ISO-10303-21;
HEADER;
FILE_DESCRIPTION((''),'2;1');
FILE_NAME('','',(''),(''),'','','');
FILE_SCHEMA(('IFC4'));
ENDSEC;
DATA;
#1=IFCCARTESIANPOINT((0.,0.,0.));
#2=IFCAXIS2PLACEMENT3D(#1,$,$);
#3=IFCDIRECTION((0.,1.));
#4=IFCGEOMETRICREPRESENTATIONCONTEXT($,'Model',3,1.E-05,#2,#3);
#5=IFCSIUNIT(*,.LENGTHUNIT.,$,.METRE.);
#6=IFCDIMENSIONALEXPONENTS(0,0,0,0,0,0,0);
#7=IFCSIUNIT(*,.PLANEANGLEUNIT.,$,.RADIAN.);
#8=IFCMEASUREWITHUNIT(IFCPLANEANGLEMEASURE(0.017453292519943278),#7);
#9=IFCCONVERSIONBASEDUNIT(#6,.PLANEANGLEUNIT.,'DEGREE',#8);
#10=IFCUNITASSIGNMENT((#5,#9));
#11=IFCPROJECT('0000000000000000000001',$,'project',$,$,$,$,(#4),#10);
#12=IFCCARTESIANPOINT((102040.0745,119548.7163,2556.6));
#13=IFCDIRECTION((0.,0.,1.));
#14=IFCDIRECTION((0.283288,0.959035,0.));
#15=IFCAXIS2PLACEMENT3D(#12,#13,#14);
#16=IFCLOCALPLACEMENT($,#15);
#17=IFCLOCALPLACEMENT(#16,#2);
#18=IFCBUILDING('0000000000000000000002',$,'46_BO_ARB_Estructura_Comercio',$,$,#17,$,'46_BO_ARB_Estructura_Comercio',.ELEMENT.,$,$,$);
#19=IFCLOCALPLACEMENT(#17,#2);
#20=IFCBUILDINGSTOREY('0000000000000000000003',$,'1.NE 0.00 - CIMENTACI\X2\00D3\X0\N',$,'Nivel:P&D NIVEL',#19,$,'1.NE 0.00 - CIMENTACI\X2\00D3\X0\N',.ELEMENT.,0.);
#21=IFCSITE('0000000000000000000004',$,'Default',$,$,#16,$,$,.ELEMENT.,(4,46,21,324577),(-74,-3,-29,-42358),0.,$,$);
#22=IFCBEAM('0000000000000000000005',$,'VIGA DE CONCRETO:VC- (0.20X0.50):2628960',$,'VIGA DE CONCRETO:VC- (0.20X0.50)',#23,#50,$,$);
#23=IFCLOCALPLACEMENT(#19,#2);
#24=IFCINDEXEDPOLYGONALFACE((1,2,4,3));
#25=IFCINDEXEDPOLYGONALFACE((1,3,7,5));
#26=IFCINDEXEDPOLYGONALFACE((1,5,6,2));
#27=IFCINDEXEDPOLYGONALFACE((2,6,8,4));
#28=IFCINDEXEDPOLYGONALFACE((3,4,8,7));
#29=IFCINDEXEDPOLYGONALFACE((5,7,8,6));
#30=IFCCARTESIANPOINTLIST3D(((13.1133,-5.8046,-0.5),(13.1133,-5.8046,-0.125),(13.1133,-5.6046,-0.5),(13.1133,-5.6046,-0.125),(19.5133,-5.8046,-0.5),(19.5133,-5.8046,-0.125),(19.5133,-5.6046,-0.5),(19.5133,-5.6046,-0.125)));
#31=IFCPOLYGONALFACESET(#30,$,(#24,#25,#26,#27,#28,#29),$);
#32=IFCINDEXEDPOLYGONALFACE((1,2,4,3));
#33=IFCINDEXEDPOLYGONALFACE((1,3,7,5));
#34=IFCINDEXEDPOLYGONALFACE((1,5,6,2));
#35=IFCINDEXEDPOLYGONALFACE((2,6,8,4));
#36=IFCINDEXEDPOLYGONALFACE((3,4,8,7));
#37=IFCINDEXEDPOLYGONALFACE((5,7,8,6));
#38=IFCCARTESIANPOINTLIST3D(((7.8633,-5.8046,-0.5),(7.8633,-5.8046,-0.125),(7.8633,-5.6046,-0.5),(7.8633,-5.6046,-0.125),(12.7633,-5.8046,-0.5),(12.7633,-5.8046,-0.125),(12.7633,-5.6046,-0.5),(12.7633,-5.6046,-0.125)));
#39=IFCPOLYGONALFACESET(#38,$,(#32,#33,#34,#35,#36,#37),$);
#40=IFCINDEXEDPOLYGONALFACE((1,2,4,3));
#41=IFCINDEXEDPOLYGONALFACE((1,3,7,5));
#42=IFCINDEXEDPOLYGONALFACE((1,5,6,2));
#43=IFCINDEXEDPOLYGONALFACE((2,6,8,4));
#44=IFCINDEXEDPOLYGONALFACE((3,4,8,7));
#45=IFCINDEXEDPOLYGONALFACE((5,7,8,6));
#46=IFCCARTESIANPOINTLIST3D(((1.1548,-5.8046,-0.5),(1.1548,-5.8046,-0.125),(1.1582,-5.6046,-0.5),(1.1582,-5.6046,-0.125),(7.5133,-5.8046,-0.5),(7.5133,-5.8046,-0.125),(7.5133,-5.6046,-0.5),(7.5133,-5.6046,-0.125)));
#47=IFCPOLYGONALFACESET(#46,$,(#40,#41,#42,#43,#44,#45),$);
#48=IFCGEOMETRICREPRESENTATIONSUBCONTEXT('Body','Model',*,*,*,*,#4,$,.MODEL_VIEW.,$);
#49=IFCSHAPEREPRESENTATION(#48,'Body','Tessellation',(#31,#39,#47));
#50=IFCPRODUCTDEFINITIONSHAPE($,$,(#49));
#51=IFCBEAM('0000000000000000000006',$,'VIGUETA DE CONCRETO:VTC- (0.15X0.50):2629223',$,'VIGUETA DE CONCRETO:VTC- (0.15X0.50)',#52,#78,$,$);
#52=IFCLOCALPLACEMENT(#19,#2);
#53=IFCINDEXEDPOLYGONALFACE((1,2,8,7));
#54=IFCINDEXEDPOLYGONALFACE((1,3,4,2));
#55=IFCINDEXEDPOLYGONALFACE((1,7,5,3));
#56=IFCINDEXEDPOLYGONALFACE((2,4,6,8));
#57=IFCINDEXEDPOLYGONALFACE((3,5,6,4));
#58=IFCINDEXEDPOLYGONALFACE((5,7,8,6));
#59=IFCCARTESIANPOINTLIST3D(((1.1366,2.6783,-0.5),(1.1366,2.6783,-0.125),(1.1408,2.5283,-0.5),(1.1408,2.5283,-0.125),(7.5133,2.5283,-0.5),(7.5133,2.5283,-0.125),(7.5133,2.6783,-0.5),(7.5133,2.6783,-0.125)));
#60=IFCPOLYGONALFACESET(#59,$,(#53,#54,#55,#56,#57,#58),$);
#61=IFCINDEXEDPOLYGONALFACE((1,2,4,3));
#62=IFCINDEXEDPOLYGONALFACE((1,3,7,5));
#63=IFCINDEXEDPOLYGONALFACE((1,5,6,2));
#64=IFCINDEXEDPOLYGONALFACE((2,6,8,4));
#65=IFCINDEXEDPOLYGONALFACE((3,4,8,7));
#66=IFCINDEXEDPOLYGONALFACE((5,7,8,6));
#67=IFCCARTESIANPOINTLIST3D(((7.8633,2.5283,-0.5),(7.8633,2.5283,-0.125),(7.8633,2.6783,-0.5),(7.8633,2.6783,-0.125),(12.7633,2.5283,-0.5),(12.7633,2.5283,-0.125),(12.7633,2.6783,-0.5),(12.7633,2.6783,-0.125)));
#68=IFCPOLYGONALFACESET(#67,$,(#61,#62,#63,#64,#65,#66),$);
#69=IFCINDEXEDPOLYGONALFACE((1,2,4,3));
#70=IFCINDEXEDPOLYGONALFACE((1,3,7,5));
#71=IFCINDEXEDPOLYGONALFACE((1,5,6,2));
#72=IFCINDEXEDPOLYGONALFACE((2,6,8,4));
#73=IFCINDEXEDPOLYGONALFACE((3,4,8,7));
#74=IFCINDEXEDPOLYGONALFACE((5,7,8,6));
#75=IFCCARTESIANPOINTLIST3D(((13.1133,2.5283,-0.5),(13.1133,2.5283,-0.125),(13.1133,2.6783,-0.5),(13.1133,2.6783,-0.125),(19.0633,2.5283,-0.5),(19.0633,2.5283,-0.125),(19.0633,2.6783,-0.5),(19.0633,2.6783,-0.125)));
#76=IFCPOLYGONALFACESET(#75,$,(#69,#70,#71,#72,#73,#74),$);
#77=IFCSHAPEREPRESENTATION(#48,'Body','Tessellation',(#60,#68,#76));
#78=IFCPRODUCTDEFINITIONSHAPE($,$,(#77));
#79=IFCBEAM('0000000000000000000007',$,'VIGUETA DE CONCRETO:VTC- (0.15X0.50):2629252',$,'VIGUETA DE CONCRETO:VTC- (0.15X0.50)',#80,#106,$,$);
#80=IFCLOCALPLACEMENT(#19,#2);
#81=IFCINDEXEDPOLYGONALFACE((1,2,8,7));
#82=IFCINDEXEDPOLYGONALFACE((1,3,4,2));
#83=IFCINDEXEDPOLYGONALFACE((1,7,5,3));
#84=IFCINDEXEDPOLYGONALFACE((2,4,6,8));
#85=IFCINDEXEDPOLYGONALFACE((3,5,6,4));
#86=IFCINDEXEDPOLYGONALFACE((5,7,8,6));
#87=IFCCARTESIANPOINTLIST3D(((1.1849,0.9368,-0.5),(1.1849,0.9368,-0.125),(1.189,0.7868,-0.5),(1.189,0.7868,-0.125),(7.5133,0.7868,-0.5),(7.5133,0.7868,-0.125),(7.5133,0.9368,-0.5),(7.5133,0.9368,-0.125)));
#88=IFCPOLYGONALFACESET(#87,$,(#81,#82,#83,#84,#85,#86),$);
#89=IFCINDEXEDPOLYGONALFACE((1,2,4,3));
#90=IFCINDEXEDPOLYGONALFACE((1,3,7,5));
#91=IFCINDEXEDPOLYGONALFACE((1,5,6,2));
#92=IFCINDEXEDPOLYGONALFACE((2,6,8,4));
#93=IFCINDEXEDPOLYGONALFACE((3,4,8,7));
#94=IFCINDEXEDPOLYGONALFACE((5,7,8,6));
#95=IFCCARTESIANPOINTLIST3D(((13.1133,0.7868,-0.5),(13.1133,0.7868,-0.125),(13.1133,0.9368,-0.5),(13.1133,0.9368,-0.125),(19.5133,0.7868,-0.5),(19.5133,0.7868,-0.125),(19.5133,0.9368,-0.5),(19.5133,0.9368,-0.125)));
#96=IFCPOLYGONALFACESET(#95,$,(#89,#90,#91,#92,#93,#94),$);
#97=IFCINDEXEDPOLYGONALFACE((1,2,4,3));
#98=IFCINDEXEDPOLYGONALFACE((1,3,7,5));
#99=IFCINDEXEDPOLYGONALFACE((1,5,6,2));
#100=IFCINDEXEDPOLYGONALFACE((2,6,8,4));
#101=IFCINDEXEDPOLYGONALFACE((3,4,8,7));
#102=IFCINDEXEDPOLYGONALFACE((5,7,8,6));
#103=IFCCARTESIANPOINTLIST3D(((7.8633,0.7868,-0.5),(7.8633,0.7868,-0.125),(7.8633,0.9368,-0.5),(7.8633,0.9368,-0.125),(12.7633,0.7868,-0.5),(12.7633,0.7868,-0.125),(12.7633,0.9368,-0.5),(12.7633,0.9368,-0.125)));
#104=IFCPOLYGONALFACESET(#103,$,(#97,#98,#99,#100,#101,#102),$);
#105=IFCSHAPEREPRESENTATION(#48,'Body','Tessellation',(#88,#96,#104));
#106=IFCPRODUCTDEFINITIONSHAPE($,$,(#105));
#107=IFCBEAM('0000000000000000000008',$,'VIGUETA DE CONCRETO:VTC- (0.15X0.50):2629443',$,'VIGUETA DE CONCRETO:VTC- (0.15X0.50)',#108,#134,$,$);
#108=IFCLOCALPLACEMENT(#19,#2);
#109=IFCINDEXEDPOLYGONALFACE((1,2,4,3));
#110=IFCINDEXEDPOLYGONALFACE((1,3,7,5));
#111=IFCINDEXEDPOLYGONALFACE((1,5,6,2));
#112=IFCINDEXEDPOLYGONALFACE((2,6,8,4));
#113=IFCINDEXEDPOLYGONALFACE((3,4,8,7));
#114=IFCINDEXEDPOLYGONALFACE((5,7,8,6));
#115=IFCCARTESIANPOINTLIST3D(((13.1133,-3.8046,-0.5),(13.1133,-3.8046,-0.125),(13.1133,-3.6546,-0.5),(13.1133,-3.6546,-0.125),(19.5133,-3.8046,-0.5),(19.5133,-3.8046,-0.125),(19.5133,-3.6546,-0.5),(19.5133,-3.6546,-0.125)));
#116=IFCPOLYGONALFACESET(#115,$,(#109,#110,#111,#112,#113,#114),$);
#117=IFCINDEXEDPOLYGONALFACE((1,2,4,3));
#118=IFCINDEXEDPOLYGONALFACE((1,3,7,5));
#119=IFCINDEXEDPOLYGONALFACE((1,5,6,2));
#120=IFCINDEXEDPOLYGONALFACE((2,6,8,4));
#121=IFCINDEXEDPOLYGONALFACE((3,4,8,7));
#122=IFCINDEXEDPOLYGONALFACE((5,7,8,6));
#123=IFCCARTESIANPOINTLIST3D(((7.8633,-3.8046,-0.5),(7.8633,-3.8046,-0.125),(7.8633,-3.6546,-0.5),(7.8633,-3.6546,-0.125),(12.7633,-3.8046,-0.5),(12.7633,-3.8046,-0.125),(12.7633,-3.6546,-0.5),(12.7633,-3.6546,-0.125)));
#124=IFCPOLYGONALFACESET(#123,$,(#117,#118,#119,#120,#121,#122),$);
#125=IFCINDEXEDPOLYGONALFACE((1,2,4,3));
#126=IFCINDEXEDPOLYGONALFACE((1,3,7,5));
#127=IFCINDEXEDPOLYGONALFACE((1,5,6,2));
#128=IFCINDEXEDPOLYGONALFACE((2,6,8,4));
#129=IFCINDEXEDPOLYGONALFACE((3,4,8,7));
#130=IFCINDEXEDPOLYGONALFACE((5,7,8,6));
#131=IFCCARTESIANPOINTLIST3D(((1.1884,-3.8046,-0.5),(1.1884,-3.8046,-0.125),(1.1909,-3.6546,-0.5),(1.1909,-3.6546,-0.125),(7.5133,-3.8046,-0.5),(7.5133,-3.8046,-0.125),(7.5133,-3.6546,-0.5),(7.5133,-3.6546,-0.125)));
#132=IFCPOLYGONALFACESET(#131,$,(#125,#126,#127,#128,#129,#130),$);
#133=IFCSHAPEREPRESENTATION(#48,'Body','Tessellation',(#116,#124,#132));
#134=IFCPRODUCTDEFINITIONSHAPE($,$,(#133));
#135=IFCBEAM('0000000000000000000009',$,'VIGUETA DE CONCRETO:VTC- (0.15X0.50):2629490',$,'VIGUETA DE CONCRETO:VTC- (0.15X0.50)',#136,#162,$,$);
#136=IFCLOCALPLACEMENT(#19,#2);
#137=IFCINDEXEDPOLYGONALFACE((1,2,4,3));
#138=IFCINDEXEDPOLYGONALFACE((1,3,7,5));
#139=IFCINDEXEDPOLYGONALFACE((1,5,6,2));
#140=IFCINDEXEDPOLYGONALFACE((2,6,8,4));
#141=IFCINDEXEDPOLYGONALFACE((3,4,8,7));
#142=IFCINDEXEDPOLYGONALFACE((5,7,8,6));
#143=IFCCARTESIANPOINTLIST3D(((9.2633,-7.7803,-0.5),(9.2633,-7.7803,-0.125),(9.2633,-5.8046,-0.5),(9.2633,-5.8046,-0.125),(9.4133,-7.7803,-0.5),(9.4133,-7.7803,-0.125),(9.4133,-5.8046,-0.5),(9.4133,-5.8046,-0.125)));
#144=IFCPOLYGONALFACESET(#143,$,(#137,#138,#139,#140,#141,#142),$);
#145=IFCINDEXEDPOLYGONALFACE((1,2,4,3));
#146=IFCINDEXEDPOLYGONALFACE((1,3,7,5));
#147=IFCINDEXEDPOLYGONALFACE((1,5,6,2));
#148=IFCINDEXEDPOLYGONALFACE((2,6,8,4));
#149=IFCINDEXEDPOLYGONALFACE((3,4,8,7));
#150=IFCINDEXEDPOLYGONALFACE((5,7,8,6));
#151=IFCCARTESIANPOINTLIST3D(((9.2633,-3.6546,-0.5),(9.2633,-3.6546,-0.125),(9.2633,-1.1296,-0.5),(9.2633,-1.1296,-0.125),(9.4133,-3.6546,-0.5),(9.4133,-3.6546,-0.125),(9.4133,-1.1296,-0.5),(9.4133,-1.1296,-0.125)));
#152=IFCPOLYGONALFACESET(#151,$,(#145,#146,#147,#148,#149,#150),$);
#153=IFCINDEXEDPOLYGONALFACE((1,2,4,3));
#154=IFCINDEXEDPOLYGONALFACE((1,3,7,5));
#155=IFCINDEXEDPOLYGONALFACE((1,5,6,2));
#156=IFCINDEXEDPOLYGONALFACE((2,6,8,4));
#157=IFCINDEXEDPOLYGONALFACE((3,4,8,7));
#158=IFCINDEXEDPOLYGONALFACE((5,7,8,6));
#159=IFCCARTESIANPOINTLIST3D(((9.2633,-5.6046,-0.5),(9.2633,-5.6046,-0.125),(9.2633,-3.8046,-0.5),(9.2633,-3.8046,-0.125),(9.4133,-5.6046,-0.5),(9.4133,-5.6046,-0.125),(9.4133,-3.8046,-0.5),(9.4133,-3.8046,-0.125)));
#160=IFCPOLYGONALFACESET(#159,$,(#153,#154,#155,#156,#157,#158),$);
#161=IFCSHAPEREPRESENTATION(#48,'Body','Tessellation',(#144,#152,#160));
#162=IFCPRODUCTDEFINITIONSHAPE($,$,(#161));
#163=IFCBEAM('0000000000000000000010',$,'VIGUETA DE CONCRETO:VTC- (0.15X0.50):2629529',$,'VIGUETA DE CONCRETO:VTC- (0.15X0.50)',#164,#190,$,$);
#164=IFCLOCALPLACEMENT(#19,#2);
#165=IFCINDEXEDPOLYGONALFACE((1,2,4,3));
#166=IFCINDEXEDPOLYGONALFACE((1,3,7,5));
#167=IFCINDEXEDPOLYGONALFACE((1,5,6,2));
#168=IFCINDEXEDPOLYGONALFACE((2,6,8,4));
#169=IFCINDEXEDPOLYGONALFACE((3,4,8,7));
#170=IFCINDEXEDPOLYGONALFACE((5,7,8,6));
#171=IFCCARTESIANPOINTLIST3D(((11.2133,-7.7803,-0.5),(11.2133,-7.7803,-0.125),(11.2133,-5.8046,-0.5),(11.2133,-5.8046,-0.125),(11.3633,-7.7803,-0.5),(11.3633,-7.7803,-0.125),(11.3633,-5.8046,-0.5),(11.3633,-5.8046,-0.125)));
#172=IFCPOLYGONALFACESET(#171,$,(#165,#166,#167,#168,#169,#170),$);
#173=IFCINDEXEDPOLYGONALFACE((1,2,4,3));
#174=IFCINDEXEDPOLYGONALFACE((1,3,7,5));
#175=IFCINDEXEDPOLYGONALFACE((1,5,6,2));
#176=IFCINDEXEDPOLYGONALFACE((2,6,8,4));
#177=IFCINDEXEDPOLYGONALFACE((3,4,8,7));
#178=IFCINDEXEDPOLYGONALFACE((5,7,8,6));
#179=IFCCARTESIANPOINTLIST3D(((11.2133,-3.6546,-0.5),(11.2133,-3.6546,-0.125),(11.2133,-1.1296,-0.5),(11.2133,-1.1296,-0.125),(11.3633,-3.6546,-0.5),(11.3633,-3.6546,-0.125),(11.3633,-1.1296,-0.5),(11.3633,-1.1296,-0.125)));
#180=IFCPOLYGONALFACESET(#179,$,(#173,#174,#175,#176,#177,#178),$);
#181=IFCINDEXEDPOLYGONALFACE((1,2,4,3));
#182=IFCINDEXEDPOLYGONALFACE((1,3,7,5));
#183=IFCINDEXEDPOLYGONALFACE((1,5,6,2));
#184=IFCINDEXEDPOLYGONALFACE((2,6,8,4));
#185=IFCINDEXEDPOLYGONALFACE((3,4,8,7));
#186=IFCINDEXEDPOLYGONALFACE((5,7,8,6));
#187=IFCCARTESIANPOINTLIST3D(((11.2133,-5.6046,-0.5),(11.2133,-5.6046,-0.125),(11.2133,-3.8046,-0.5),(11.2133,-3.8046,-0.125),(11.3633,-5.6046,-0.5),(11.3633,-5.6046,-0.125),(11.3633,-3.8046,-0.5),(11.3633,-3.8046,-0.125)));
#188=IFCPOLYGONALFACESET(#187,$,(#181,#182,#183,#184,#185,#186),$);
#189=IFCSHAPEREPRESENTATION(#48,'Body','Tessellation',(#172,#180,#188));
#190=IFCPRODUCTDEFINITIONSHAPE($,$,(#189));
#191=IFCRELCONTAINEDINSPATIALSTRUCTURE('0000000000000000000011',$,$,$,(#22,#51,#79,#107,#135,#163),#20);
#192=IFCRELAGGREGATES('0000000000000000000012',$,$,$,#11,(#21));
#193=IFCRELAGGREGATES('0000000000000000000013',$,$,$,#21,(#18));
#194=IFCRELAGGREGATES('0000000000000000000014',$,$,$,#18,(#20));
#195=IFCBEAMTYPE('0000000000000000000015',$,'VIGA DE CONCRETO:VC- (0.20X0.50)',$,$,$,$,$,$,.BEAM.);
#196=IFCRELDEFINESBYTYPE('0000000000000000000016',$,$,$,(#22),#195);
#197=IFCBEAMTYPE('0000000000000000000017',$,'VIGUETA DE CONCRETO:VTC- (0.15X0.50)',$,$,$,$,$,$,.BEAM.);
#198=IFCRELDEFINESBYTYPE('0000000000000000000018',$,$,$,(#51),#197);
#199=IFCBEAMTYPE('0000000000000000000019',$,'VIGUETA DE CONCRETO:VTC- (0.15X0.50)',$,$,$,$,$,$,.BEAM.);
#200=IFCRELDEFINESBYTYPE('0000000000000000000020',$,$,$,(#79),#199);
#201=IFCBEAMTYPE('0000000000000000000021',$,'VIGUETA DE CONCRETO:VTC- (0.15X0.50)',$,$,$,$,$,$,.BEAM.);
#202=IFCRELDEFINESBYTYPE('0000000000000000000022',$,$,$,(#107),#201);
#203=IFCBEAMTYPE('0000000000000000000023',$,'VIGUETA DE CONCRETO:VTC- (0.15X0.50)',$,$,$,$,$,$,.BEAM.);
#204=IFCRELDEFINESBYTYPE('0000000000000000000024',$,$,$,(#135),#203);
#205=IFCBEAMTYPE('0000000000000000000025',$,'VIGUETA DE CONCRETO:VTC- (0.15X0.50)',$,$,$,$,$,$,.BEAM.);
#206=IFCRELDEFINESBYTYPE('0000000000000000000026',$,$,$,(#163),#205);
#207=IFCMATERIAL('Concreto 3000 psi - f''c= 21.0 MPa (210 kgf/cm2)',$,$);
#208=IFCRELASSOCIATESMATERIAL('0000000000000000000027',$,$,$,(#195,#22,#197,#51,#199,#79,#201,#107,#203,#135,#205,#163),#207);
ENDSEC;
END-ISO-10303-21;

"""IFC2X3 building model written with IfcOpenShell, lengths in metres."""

from ifc_helpers import new_model, entity, si_unit, converted_unit, direction, frame, frame_2d, origin, origin_2d_with_axis, place, context, subcontext, project, spatial, rectangle, extrude, clip, halfspace, source, transform, mapped, material, type_object, type_shapes, element, save


model = new_model("IFC2X3")

# Units and contexts
model_context = context("Model", 3, precision=1e-05, world=origin(), true_north=direction((0.0, 1.0)))
body_context = subcontext(model_context, "Body", "Model", "MODEL_VIEW")
ifc_project = project(units=[si_unit("LENGTHUNIT", "METRE"), converted_unit("PLANEANGLEUNIT", "DEGREE", entity("IfcPlaneAngleMeasure", 0.017453292519943278), si_unit("PLANEANGLEUNIT", "RADIAN"), dimensions=[0, 0, 0, 0, 0, 0, 0])], contexts=[model_context])

# Site, building, storey
site_placement = place(None, frame((102040.0745, 119548.7163, 2556.6), z_axis=(0.0, 0.0, 1.0), x_axis=(0.283288, 0.959035, 0.0)))
site = spatial("IfcSite", under=ifc_project, at=site_placement, Name="Default", CompositionType="ELEMENT", RefLatitude=(4, 46, 21, 324577), RefLongitude=(-74, -3, -29, -42358), RefElevation=0.0)
building_placement = place(site_placement, origin())
building = spatial("IfcBuilding", under=site, at=building_placement, Name="46_BO_ARB_Estructura_Comercio", LongName="46_BO_ARB_Estructura_Comercio", CompositionType="ELEMENT")
storey_placement = place(building_placement, origin())
storey = spatial("IfcBuildingStorey", under=building, at=storey_placement, Name="1.NE 0.00 - CIMENTACIÓN", ObjectType="Nivel:P&D NIVEL", LongName="1.NE 0.00 - CIMENTACIÓN", CompositionType="ELEMENT", Elevation=0.0)

# Beams
ifc_material_1 = material(Name="Concreto 3000 psi - f'c= 21.0 MPa (210 kgf/cm2)")
beam_type_1 = type_object("IfcBeamType", Name="VIGA DE CONCRETO:VC- (0.20X0.50)", PredefinedType="BEAM", material=ifc_material_1)
shared_shape_1 = source(origin(), body_context, "Body", "SweptSolid", [
    extrude(rectangle(XDim=0.375, YDim=0.2, at=frame_2d((0.0, 0.0), x_axis=(1.0, 0.0))), frame((13.1133, -5.7046, -0.3125), z_axis=(1.0, 0.0, 0.0), x_axis=(0.0, 0.0, -1.0)), (0.0, 0.0, 1.0), 6.4),
    extrude(rectangle(XDim=0.375, YDim=0.2, at=frame_2d((0.0, 0.0), x_axis=(1.0, 0.0))), frame((7.8633, -5.7046, -0.3125), z_axis=(1.0, 0.0, 0.0), x_axis=(0.0, 0.0, -1.0)), (0.0, 0.0, 1.0), 4.9),
    clip(extrude(rectangle(XDim=0.375, YDim=0.2, at=origin_2d_with_axis()), frame((1.1548, -5.7046, -0.3125), z_axis=(1.0, 0.0, 0.0), x_axis=(0.0, 0.0, -1.0)), (0.0, 0.0, 1.0), 6.3585), halfspace(frame((1.2358, -0.978, 0.0), z_axis=(-0.999859, 0.016768, 0.0), x_axis=(-0.016768, -0.999859, 0.0)), False)),
])
type_shapes(beam_type_1, [shared_shape_1])
beam_1_placement = place(storey_placement, origin())
element("IfcBeam", 1, at=beam_1_placement, inside=storey, type_object=beam_type_1, material=ifc_material_1, Name="VIGA DE CONCRETO:VC- (0.20X0.50):2628960", ObjectType="VIGA DE CONCRETO:VC- (0.20X0.50)", context=body_context, shape_type="MappedRepresentation", body=[
    mapped(shared_shape_1, transform((0.0, 0.0, 0.0), scale=1.0)),
])
beam_type_2 = type_object("IfcBeamType", Name="VIGUETA DE CONCRETO:VTC- (0.15X0.50)", PredefinedType="BEAM", material=ifc_material_1)
shared_shape_2 = source(origin(), body_context, "Body", "SweptSolid", [
    clip(extrude(rectangle(XDim=0.375, YDim=0.15, at=frame_2d((0.0, 0.0), x_axis=(1.0, 0.0))), frame((1.1366, 2.6033, -0.3125), z_axis=(1.0, 0.0, 0.0), x_axis=(0.0, 0.0, -1.0)), (0.0, 0.0, 1.0), 6.3767), halfspace(frame((1.0943, 4.207, 0.0), z_axis=(-0.999616, -0.027697, 0.0), x_axis=(0.027697, -0.999616, 0.0)), False)),
    extrude(rectangle(XDim=0.375, YDim=0.15, at=frame_2d((0.0, 0.0), x_axis=(1.0, 0.0))), frame((7.8633, 2.6033, -0.3125), z_axis=(1.0, 0.0, 0.0), x_axis=(0.0, 0.0, -1.0)), (0.0, 0.0, 1.0), 4.9),
    extrude(rectangle(XDim=0.375, YDim=0.15, at=frame_2d((0.0, 0.0), x_axis=(1.0, 0.0))), frame((13.1133, 2.6033, -0.3125), z_axis=(1.0, 0.0, 0.0), x_axis=(0.0, 0.0, -1.0)), (0.0, 0.0, 1.0), 5.95),
])
type_shapes(beam_type_2, [shared_shape_2])
beam_2_placement = place(storey_placement, origin())
element("IfcBeam", 2, at=beam_2_placement, inside=storey, type_object=beam_type_2, material=ifc_material_1, Name="VIGUETA DE CONCRETO:VTC- (0.15X0.50):2629223", ObjectType="VIGUETA DE CONCRETO:VTC- (0.15X0.50)", context=body_context, shape_type="MappedRepresentation", body=[
    mapped(shared_shape_2, transform((0.0, 0.0, 0.0), scale=1.0)),
])
beam_type_3 = type_object("IfcBeamType", Name="VIGUETA DE CONCRETO:VTC- (0.15X0.50)", PredefinedType="BEAM", material=ifc_material_1)
shared_shape_3 = source(origin(), body_context, "Body", "SweptSolid", [
    clip(extrude(rectangle(XDim=0.375, YDim=0.15, at=frame_2d((0.0, 0.0), x_axis=(1.0, 0.0))), frame((1.1849, 0.8618, -0.3125), z_axis=(1.0, 0.0, 0.0), x_axis=(0.0, 0.0, -1.0)), (0.0, 0.0, 1.0), 6.3284), halfspace(frame((1.0943, 4.207, 0.0), z_axis=(-0.999616, -0.027697, 0.0), x_axis=(0.027697, -0.999616, 0.0)), False)),
    extrude(rectangle(XDim=0.375, YDim=0.15, at=frame_2d((0.0, 0.0), x_axis=(1.0, 0.0))), frame((13.1133, 0.8618, -0.3125), z_axis=(1.0, 0.0, 0.0), x_axis=(0.0, 0.0, -1.0)), (0.0, 0.0, 1.0), 6.4),
    extrude(rectangle(XDim=0.375, YDim=0.15, at=frame_2d((0.0, 0.0), x_axis=(1.0, 0.0))), frame((7.8633, 0.8618, -0.3125), z_axis=(1.0, 0.0, 0.0), x_axis=(0.0, 0.0, -1.0)), (0.0, 0.0, 1.0), 4.9),
])
type_shapes(beam_type_3, [shared_shape_3])
beam_3_placement = place(storey_placement, origin())
element("IfcBeam", 3, at=beam_3_placement, inside=storey, type_object=beam_type_3, material=ifc_material_1, Name="VIGUETA DE CONCRETO:VTC- (0.15X0.50):2629252", ObjectType="VIGUETA DE CONCRETO:VTC- (0.15X0.50)", context=body_context, shape_type="MappedRepresentation", body=[
    mapped(shared_shape_3, transform((0.0, 0.0, 0.0), scale=1.0)),
])
beam_type_4 = type_object("IfcBeamType", Name="VIGUETA DE CONCRETO:VTC- (0.15X0.50)", PredefinedType="BEAM", material=ifc_material_1)
shared_shape_4 = source(origin(), body_context, "Body", "SweptSolid", [
    extrude(rectangle(XDim=0.375, YDim=0.15, at=origin_2d_with_axis()), frame((13.1133, -3.7296, -0.3125), z_axis=(1.0, 0.0, 0.0), x_axis=(0.0, 0.0, -1.0)), (0.0, 0.0, 1.0), 6.4),
    extrude(rectangle(XDim=0.375, YDim=0.15, at=origin_2d_with_axis()), frame((7.8633, -3.7296, -0.3125), z_axis=(1.0, 0.0, 0.0), x_axis=(0.0, 0.0, -1.0)), (0.0, 0.0, 1.0), 4.9),
    clip(extrude(rectangle(XDim=0.375, YDim=0.15, at=frame_2d((0.0, 0.0), x_axis=(1.0, 0.0))), frame((1.1884, -3.7296, -0.3125), z_axis=(1.0, 0.0, 0.0), x_axis=(0.0, 0.0, -1.0)), (0.0, 0.0, 1.0), 6.3249), halfspace(frame((1.2358, -0.978, 0.0), z_axis=(-0.999859, 0.016768, 0.0), x_axis=(-0.016768, -0.999859, 0.0)), False)),
])
type_shapes(beam_type_4, [shared_shape_4])
beam_4_placement = place(storey_placement, origin())
element("IfcBeam", 4, at=beam_4_placement, inside=storey, type_object=beam_type_4, material=ifc_material_1, Name="VIGUETA DE CONCRETO:VTC- (0.15X0.50):2629443", ObjectType="VIGUETA DE CONCRETO:VTC- (0.15X0.50)", context=body_context, shape_type="MappedRepresentation", body=[
    mapped(shared_shape_4, transform((0.0, 0.0, 0.0), scale=1.0)),
])
beam_type_5 = type_object("IfcBeamType", Name="VIGUETA DE CONCRETO:VTC- (0.15X0.50)", PredefinedType="BEAM", material=ifc_material_1)
shared_shape_5 = source(origin(), body_context, "Body", "SweptSolid", [
    extrude(rectangle(XDim=0.375, YDim=0.15, at=frame_2d((0.0, 0.0), x_axis=(0.0, 1.0))), frame((9.3383, -7.7803, -0.3125), z_axis=(0.0, 1.0, 0.0), x_axis=(-1.0, 0.0, 0.0)), (0.0, 0.0, 1.0), 1.9757),
    extrude(rectangle(XDim=0.375, YDim=0.15, at=frame_2d((0.0, 0.0), x_axis=(0.0, 1.0))), frame((9.3383, -3.6546, -0.3125), z_axis=(0.0, 1.0, 0.0), x_axis=(-1.0, 0.0, 0.0)), (0.0, 0.0, 1.0), 2.525),
    extrude(rectangle(XDim=0.375, YDim=0.15, at=frame_2d((0.0, 0.0), x_axis=(0.0, 1.0))), frame((9.3383, -5.6046, -0.3125), z_axis=(0.0, 1.0, 0.0), x_axis=(-1.0, 0.0, 0.0)), (0.0, 0.0, 1.0), 1.8),
])
type_shapes(beam_type_5, [shared_shape_5])
beam_5_placement = place(storey_placement, origin())
element("IfcBeam", 5, at=beam_5_placement, inside=storey, type_object=beam_type_5, material=ifc_material_1, Name="VIGUETA DE CONCRETO:VTC- (0.15X0.50):2629490", ObjectType="VIGUETA DE CONCRETO:VTC- (0.15X0.50)", context=body_context, shape_type="MappedRepresentation", body=[
    mapped(shared_shape_5, transform((0.0, 0.0, 0.0), scale=1.0)),
])
beam_type_6 = type_object("IfcBeamType", Name="VIGUETA DE CONCRETO:VTC- (0.15X0.50)", PredefinedType="BEAM", material=ifc_material_1)
shared_shape_6 = source(origin(), body_context, "Body", "SweptSolid", [
    extrude(rectangle(XDim=0.375, YDim=0.15, at=frame_2d((0.0, 0.0), x_axis=(0.0, 1.0))), frame((11.2883, -7.7803, -0.3125), z_axis=(0.0, 1.0, 0.0), x_axis=(-1.0, 0.0, 0.0)), (0.0, 0.0, 1.0), 1.9757),
    extrude(rectangle(XDim=0.375, YDim=0.15, at=frame_2d((0.0, 0.0), x_axis=(0.0, 1.0))), frame((11.2883, -3.6546, -0.3125), z_axis=(0.0, 1.0, 0.0), x_axis=(-1.0, 0.0, 0.0)), (0.0, 0.0, 1.0), 2.525),
    extrude(rectangle(XDim=0.375, YDim=0.15, at=frame_2d((0.0, 0.0), x_axis=(0.0, 1.0))), frame((11.2883, -5.6046, -0.3125), z_axis=(0.0, 1.0, 0.0), x_axis=(-1.0, 0.0, 0.0)), (0.0, 0.0, 1.0), 1.8),
])
type_shapes(beam_type_6, [shared_shape_6])
beam_6_placement = place(storey_placement, origin())
element("IfcBeam", 6, at=beam_6_placement, inside=storey, type_object=beam_type_6, material=ifc_material_1, Name="VIGUETA DE CONCRETO:VTC- (0.15X0.50):2629529", ObjectType="VIGUETA DE CONCRETO:VTC- (0.15X0.50)", context=body_context, shape_type="MappedRepresentation", body=[
    mapped(shared_shape_6, transform((0.0, 0.0, 0.0), scale=1.0)),
])

save(model, "model.ifc")
